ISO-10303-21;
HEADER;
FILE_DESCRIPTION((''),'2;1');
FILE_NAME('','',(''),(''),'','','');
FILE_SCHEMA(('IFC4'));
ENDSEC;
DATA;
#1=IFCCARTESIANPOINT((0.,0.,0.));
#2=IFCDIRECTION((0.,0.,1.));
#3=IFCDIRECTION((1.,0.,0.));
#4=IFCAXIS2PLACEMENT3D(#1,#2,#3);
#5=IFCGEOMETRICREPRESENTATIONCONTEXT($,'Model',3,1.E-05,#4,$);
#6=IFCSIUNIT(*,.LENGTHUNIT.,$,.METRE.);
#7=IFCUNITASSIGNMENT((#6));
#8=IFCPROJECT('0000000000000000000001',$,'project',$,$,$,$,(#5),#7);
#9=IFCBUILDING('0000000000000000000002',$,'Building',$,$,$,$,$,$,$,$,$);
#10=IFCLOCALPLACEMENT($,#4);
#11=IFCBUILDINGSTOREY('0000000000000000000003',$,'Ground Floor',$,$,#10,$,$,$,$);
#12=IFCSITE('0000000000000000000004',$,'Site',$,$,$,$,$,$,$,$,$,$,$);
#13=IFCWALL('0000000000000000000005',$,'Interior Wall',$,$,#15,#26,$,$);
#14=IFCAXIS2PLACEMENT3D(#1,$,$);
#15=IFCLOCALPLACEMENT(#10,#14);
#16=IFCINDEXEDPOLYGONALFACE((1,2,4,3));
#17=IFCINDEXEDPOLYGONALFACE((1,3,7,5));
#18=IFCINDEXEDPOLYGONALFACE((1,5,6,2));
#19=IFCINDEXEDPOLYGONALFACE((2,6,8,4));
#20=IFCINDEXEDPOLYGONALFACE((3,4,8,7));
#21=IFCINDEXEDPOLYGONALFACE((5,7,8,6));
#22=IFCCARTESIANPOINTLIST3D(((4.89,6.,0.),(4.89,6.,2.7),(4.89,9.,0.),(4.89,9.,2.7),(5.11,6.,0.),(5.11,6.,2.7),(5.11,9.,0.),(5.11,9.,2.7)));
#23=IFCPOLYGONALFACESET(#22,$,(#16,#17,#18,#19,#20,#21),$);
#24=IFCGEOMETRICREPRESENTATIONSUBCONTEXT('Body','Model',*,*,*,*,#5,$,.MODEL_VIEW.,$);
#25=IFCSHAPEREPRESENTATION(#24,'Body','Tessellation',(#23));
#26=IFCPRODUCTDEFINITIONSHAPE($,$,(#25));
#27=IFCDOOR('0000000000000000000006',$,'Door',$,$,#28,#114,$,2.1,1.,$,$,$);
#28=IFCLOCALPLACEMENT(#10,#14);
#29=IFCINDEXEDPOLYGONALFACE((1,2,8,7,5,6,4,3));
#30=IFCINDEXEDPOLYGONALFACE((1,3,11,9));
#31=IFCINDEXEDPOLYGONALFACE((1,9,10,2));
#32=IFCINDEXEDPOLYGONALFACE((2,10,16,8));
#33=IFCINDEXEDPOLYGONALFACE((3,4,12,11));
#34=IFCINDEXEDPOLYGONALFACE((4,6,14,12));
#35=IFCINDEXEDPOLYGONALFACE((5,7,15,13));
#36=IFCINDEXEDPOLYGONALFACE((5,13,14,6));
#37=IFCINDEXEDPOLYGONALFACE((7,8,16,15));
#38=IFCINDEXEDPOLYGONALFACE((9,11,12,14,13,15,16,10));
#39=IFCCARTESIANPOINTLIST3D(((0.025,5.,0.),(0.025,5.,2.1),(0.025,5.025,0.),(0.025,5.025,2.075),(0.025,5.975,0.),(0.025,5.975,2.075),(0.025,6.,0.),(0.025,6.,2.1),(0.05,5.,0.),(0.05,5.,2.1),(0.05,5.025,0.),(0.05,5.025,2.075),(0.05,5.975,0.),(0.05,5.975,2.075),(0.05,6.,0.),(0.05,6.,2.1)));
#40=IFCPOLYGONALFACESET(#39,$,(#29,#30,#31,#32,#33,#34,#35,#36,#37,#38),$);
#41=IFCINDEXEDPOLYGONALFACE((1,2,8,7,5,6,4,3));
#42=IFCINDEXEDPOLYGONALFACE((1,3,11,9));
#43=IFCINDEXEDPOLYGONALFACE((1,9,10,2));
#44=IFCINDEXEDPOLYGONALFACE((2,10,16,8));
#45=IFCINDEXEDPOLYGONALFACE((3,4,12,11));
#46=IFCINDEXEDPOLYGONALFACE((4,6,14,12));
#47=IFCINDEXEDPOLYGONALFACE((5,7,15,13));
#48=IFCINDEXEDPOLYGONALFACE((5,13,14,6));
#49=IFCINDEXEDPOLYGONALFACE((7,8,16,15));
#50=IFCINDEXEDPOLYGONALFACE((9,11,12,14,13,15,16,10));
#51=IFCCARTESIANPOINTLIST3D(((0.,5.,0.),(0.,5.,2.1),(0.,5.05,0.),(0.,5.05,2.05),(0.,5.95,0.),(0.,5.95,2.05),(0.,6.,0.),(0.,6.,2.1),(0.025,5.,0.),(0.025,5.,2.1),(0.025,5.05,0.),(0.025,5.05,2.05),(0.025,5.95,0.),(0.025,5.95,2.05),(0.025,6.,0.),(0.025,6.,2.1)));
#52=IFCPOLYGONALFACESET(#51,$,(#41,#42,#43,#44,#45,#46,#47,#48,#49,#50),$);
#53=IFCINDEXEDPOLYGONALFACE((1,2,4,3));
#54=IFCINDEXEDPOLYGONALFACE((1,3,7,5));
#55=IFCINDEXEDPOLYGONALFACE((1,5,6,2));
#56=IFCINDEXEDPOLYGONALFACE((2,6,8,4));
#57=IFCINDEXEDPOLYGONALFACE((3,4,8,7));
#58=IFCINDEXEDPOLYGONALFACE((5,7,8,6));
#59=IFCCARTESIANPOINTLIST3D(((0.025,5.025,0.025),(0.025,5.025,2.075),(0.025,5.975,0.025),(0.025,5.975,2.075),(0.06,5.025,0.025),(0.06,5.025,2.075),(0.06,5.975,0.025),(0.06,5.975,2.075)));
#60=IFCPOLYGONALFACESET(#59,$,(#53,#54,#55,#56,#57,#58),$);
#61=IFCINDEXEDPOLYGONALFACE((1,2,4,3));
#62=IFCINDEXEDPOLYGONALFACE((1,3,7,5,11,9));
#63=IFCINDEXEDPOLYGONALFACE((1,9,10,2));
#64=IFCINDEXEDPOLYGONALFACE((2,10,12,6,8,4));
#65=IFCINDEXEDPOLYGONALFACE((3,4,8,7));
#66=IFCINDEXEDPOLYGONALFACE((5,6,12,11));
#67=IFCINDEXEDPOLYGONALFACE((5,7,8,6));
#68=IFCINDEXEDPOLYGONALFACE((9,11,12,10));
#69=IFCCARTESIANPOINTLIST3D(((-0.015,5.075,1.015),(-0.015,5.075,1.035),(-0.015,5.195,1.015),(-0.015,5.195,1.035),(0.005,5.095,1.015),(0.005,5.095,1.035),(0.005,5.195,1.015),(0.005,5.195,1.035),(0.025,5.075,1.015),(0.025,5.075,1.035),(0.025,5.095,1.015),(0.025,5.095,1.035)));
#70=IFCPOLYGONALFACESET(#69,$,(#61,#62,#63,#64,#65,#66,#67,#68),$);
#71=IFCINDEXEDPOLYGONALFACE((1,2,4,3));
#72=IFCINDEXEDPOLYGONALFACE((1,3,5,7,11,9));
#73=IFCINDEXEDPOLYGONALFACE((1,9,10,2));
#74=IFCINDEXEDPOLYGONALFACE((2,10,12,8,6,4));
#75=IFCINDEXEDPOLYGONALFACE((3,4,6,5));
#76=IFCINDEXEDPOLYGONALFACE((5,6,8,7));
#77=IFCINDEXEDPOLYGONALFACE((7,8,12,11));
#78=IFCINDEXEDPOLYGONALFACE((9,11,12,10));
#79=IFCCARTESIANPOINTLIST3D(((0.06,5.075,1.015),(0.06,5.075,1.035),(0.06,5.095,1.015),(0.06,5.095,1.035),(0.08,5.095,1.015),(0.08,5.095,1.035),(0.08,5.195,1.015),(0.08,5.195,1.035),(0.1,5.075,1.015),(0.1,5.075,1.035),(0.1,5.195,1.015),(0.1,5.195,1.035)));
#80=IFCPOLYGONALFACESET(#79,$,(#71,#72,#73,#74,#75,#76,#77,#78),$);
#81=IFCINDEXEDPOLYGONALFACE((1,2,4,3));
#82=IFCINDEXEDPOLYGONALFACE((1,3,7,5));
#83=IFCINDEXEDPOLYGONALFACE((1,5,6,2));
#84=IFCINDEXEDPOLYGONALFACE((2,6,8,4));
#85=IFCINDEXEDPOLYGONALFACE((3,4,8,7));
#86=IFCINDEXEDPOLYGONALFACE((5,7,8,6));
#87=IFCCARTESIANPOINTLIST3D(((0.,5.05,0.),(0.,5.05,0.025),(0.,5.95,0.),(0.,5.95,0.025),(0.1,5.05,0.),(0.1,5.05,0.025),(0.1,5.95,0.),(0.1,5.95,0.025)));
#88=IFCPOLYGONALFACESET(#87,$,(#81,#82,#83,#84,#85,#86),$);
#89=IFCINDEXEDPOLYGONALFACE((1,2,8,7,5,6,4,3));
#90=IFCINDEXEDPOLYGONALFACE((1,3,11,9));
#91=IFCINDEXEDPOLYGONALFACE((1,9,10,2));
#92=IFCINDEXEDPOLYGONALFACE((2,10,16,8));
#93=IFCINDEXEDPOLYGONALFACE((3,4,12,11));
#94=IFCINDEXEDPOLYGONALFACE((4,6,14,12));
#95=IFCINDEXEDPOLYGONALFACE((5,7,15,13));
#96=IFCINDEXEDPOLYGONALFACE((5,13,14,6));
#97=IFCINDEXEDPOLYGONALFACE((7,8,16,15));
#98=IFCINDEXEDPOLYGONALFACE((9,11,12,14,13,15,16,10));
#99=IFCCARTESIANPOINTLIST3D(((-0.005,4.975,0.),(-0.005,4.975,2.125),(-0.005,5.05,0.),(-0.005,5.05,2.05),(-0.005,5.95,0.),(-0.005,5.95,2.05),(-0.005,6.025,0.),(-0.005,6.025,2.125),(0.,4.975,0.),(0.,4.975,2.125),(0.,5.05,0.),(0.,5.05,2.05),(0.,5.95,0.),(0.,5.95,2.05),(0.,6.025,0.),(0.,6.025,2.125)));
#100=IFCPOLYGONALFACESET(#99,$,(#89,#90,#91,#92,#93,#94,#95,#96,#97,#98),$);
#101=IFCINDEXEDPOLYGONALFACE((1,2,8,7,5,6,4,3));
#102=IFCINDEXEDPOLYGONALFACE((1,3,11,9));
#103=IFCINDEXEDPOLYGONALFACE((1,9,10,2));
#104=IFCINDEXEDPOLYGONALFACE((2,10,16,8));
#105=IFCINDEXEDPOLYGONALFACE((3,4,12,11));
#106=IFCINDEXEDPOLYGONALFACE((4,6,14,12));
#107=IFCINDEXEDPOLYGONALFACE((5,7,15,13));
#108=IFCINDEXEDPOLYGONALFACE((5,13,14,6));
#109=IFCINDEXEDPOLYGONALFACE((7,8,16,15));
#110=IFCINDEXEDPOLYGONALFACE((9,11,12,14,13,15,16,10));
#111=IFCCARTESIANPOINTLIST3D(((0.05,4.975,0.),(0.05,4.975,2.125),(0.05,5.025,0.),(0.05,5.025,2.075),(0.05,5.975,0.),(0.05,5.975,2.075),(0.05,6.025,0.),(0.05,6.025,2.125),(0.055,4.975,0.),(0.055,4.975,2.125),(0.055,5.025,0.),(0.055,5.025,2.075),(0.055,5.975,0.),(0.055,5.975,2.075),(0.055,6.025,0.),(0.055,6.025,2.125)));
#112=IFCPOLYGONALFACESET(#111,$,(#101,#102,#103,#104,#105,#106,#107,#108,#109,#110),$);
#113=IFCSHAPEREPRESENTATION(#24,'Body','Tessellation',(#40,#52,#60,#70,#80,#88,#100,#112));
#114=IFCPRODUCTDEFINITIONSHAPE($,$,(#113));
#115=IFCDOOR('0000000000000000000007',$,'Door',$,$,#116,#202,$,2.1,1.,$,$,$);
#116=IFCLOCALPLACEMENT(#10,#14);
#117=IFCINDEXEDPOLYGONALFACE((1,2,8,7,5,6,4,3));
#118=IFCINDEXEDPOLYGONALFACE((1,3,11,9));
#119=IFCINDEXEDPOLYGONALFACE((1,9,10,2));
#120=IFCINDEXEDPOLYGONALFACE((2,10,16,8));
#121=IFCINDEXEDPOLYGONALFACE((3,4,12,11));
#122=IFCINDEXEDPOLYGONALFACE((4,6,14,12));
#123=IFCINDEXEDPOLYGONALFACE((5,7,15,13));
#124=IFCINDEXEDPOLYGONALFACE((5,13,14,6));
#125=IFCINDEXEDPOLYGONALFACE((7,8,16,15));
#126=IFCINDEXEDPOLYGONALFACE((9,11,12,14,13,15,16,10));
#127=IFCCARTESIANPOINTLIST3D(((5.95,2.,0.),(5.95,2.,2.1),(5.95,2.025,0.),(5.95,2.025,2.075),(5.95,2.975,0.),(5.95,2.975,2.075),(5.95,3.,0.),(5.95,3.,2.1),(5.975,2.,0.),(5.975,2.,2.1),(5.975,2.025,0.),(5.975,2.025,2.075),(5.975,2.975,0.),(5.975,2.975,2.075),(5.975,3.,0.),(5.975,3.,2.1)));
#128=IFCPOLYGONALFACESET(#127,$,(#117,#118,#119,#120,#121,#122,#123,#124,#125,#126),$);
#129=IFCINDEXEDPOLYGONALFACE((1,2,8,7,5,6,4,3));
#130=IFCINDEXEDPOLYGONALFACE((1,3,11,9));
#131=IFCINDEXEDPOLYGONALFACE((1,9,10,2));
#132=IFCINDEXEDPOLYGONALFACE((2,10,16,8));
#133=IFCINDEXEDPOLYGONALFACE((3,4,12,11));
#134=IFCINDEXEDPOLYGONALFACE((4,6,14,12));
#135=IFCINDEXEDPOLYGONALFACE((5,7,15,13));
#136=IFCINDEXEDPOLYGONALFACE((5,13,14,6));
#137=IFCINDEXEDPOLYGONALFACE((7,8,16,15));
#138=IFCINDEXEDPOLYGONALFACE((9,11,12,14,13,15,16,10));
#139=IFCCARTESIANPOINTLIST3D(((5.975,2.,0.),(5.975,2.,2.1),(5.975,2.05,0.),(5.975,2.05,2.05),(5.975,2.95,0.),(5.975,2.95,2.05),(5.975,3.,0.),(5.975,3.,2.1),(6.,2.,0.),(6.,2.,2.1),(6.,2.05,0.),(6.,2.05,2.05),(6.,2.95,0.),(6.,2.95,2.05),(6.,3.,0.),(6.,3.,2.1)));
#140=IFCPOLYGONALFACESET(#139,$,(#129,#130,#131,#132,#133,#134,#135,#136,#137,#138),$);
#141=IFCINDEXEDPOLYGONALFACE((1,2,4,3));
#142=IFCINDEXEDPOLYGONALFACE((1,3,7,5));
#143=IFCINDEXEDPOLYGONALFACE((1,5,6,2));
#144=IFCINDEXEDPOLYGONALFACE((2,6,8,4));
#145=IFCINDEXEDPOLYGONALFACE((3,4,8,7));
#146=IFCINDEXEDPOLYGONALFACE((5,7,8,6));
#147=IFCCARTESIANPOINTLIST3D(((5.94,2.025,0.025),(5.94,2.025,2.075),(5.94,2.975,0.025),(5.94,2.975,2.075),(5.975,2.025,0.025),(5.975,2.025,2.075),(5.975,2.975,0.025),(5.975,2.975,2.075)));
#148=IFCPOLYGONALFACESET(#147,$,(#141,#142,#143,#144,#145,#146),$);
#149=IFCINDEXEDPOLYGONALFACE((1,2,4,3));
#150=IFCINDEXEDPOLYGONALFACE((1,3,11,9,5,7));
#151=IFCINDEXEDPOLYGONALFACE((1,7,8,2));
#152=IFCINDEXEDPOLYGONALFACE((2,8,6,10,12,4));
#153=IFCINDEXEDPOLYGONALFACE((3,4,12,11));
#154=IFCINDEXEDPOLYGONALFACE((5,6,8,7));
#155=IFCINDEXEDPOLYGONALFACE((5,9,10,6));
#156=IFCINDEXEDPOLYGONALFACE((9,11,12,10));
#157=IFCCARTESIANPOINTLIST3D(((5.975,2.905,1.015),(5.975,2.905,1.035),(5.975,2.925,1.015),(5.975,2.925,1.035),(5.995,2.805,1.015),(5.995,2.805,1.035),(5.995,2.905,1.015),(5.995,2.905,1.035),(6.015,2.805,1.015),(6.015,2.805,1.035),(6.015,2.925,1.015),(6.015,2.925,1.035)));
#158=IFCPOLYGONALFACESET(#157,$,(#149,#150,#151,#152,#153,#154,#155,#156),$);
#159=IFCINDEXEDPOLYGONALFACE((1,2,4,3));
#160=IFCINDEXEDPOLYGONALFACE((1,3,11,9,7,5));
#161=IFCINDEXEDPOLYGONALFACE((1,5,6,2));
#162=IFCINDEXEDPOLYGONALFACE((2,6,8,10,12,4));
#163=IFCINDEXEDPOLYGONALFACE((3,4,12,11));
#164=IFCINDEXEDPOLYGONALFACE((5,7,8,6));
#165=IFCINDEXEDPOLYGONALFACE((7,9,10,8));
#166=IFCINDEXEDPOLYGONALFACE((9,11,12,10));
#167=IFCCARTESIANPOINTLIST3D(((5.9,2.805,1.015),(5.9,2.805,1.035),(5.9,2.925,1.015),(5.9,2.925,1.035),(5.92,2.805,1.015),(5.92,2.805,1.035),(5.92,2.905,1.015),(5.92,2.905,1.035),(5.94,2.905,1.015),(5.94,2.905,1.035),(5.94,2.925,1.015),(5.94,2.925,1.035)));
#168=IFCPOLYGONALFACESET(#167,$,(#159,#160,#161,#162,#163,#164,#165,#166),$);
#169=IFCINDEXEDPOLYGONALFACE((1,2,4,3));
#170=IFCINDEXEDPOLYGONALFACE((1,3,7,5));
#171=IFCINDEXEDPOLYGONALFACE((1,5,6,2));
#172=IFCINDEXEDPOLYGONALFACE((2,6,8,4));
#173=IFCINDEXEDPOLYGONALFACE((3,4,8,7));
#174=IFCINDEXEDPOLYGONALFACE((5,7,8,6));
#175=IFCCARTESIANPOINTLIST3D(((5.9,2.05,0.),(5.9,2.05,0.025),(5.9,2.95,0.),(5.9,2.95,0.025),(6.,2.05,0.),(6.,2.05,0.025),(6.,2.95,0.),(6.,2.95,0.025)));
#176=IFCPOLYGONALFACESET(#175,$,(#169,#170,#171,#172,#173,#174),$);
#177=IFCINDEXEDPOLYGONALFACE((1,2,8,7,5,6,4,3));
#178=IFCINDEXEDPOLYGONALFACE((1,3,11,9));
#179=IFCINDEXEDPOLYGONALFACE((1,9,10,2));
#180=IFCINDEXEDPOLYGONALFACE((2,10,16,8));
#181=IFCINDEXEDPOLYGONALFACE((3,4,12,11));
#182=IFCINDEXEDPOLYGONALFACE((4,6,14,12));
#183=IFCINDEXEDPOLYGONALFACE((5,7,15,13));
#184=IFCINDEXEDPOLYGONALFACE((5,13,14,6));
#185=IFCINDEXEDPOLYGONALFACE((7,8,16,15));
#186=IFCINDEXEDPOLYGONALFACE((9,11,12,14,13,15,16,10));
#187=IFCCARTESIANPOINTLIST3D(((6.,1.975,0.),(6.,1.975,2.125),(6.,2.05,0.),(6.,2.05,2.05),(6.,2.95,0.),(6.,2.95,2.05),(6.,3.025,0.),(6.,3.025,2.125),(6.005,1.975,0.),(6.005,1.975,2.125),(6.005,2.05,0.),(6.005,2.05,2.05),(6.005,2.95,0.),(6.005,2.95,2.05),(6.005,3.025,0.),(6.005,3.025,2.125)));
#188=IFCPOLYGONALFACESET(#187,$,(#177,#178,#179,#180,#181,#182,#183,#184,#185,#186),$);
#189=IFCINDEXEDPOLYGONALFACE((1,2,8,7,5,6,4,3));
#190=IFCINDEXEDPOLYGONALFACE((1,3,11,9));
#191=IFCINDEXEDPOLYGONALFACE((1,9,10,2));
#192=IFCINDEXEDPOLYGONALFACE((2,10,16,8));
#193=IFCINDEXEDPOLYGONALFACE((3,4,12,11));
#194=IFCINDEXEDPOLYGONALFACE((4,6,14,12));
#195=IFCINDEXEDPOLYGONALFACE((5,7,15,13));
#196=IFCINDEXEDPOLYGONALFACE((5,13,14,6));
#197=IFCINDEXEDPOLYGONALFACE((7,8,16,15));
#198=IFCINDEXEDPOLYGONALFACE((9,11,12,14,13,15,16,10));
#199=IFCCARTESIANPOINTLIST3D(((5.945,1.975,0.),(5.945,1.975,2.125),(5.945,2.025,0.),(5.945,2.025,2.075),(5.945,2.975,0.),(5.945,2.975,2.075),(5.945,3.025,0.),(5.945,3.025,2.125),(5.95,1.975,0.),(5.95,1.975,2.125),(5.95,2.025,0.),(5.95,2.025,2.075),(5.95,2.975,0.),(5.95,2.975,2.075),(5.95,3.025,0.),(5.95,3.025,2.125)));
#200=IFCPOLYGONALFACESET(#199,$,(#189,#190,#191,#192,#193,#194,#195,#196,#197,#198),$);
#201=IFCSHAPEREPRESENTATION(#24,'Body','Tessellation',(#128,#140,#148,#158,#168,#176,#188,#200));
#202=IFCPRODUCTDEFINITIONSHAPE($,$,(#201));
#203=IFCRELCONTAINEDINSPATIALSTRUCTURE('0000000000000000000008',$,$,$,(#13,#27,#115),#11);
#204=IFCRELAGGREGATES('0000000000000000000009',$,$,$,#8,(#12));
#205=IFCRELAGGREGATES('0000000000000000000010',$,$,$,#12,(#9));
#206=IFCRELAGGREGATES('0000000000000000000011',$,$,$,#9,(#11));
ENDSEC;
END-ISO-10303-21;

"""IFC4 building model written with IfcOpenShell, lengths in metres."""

from ifc_helpers import new_model, si_unit, frame, origin_with_axes, place, context, subcontext, project, spatial, line, indexed_curve, outline, extrude, element, save


model = new_model("IFC4")

# Units and contexts
model_context = context("Model", 3, precision=1e-05, world=origin_with_axes())
body_context = subcontext(model_context, "Body", "Model", "MODEL_VIEW")
ifc_project = project(units=[si_unit("LENGTHUNIT", "METRE")], contexts=[model_context])

# Site, building, storey
site = spatial("IfcSite", under=ifc_project, Name="Site")
building = spatial("IfcBuilding", under=site, Name="Building")
storey_placement = place(None, origin_with_axes())
storey = spatial("IfcBuildingStorey", under=building, at=storey_placement, Name="Ground Floor")

# Wall
wall_1_placement = place(storey_placement, frame((5.0, 6.0, 0.0), z_axis=(0.0, 0.0, 1.0), x_axis=(0.0, 1.0, 0.0)))
element("IfcWall", 1, at=wall_1_placement, inside=storey, Name="Interior Wall", context=body_context, shape_type="SweptSolid", body=[
    extrude(outline(indexed_curve([(0.0, 0.0), (0.0, 0.22), (3.0, 0.22), (3.0, 0.0), (0.0, 0.0)], self_intersect=False)), frame((0.0, -0.11, 0.0), z_axis=(0.0, 0.0, 1.0), x_axis=(1.0, 0.0, 0.0)), (0.0, 0.0, 1.0), 2.7),
])

# Doors
door_1_placement = place(storey_placement, frame((0.0, 6.0, 0.0), z_axis=(0.0, 0.0, 1.0), x_axis=(0.0, -1.0, 0.0)))
element("IfcDoor", 2, at=door_1_placement, inside=storey, Name="Door", OverallHeight=2.1, OverallWidth=1.0, context=body_context, shape_type="SweptSolid", body=[
    extrude(outline(indexed_curve([(0.0, 0.0), (0.0, 2.1), (1.0, 2.1), (1.0, 0.0), (0.975, 0.0), (0.975, 2.075), (0.025, 2.075), (0.025, 0.0)], segments=[line(1, 2, 3, 4, 5, 6, 7, 8, 1)])), frame((0.0, 0.025, 0.0), z_axis=(0.0, -1.0, 0.0), x_axis=(1.0, 0.0, 0.0)), (0.0, 0.0, -1.0), 0.025),
    extrude(outline(indexed_curve([(0.0, 0.0), (0.0, 2.1), (1.0, 2.1), (1.0, 0.0), (0.95, 0.0), (0.95, 2.05), (0.05, 2.05), (0.05, 0.0)], segments=[line(1, 2, 3, 4, 5, 6, 7, 8, 1)])), frame((0.0, 0.0, 0.0), z_axis=(0.0, -1.0, 0.0), x_axis=(1.0, 0.0, 0.0)), (0.0, 0.0, -1.0), 0.025),
    extrude(outline(indexed_curve([(0.0, 0.0), (0.95, 0.0), (0.95, 0.035), (0.0, 0.035)], segments=[line(1, 2, 3, 4, 1)])), frame((0.025, 0.025, 0.025), z_axis=(0.0, 0.0, 1.0), x_axis=(1.0, 0.0, 0.0)), (0.0, 0.0, 1.0), 2.05),
    extrude(outline(indexed_curve([(0.0, 0.0), (0.0, -0.04), (-0.12, -0.04), (-0.12, -0.02), (-0.02, -0.02), (-0.02, 0.0)], segments=[line(1, 2, 3, 4, 5, 6, 1)])), frame((0.925, 0.025, 1.015), z_axis=(0.0, 0.0, 1.0), x_axis=(1.0, 0.0, 0.0)), (0.0, 0.0, 1.0), 0.02),
    extrude(outline(indexed_curve([(0.0, 0.0), (0.0, 0.04), (-0.12, 0.04), (-0.12, 0.02), (-0.02, 0.02), (-0.02, 0.0)], segments=[line(1, 2, 3, 4, 5, 6, 1)])), frame((0.925, 0.06, 1.015), z_axis=(0.0, 0.0, 1.0), x_axis=(1.0, 0.0, 0.0)), (0.0, 0.0, 1.0), 0.02),
    extrude(outline(indexed_curve([(0.0, 0.0), (0.9, 0.0), (0.9, 0.1), (0.0, 0.1)], segments=[line(1, 2, 3, 4, 1)])), frame((0.05, 0.0, 0.0), z_axis=(0.0, 0.0, 1.0), x_axis=(1.0, 0.0, 0.0)), (0.0, 0.0, 1.0), 0.025),
    extrude(outline(indexed_curve([(0.0, 0.0), (0.0, 2.125), (1.05, 2.125), (1.05, 0.0), (0.975, 0.0), (0.975, 2.05), (0.075, 2.05), (0.075, 0.0)], segments=[line(1, 2, 3, 4, 5, 6, 7, 8, 1)])), frame((-0.025, -0.005, 0.0), z_axis=(0.0, -1.0, 0.0), x_axis=(1.0, 0.0, 0.0)), (0.0, 0.0, -1.0), 0.005),
    extrude(outline(indexed_curve([(0.0, 0.0), (0.0, 2.125), (1.05, 2.125), (1.05, 0.0), (1.0, 0.0), (1.0, 2.075), (0.05, 2.075), (0.05, 0.0)], segments=[line(1, 2, 3, 4, 5, 6, 7, 8, 1)])), frame((-0.025, 0.05, 0.0), z_axis=(0.0, -1.0, 0.0), x_axis=(1.0, 0.0, 0.0)), (0.0, 0.0, -1.0), 0.005),
])
door_2_placement = place(storey_placement, frame((6.0, 2.0, 0.0), z_axis=(0.0, 0.0, 1.0), x_axis=(0.0, 1.0, 0.0)))
element("IfcDoor", 3, at=door_2_placement, inside=storey, Name="Door", OverallHeight=2.1, OverallWidth=1.0, context=body_context, shape_type="SweptSolid", body=[
    extrude(outline(indexed_curve([(0.0, 0.0), (0.0, 2.1), (1.0, 2.1), (1.0, 0.0), (0.975, 0.0), (0.975, 2.075), (0.025, 2.075), (0.025, 0.0)], segments=[line(1, 2, 3, 4, 5, 6, 7, 8, 1)])), frame((0.0, 0.025, 0.0), z_axis=(0.0, -1.0, 0.0), x_axis=(1.0, 0.0, 0.0)), (0.0, 0.0, -1.0), 0.025),
    extrude(outline(indexed_curve([(0.0, 0.0), (0.0, 2.1), (1.0, 2.1), (1.0, 0.0), (0.95, 0.0), (0.95, 2.05), (0.05, 2.05), (0.05, 0.0)], segments=[line(1, 2, 3, 4, 5, 6, 7, 8, 1)])), frame((0.0, 0.0, 0.0), z_axis=(0.0, -1.0, 0.0), x_axis=(1.0, 0.0, 0.0)), (0.0, 0.0, -1.0), 0.025),
    extrude(outline(indexed_curve([(0.0, 0.0), (0.95, 0.0), (0.95, 0.035), (0.0, 0.035)], segments=[line(1, 2, 3, 4, 1)])), frame((0.025, 0.025, 0.025), z_axis=(0.0, 0.0, 1.0), x_axis=(1.0, 0.0, 0.0)), (0.0, 0.0, 1.0), 2.05),
    extrude(outline(indexed_curve([(0.0, 0.0), (0.0, -0.04), (-0.12, -0.04), (-0.12, -0.02), (-0.02, -0.02), (-0.02, 0.0)], segments=[line(1, 2, 3, 4, 5, 6, 1)])), frame((0.925, 0.025, 1.015), z_axis=(0.0, 0.0, 1.0), x_axis=(1.0, 0.0, 0.0)), (0.0, 0.0, 1.0), 0.02),
    extrude(outline(indexed_curve([(0.0, 0.0), (0.0, 0.04), (-0.12, 0.04), (-0.12, 0.02), (-0.02, 0.02), (-0.02, 0.0)], segments=[line(1, 2, 3, 4, 5, 6, 1)])), frame((0.925, 0.06, 1.015), z_axis=(0.0, 0.0, 1.0), x_axis=(1.0, 0.0, 0.0)), (0.0, 0.0, 1.0), 0.02),
    extrude(outline(indexed_curve([(0.0, 0.0), (0.9, 0.0), (0.9, 0.1), (0.0, 0.1)], segments=[line(1, 2, 3, 4, 1)])), frame((0.05, 0.0, 0.0), z_axis=(0.0, 0.0, 1.0), x_axis=(1.0, 0.0, 0.0)), (0.0, 0.0, 1.0), 0.025),
    extrude(outline(indexed_curve([(0.0, 0.0), (0.0, 2.125), (1.05, 2.125), (1.05, 0.0), (0.975, 0.0), (0.975, 2.05), (0.075, 2.05), (0.075, 0.0)], segments=[line(1, 2, 3, 4, 5, 6, 7, 8, 1)])), frame((-0.025, -0.005, 0.0), z_axis=(0.0, -1.0, 0.0), x_axis=(1.0, 0.0, 0.0)), (0.0, 0.0, -1.0), 0.005),
    extrude(outline(indexed_curve([(0.0, 0.0), (0.0, 2.125), (1.05, 2.125), (1.05, 0.0), (1.0, 0.0), (1.0, 2.075), (0.05, 2.075), (0.05, 0.0)], segments=[line(1, 2, 3, 4, 5, 6, 7, 8, 1)])), frame((-0.025, 0.05, 0.0), z_axis=(0.0, -1.0, 0.0), x_axis=(1.0, 0.0, 0.0)), (0.0, 0.0, -1.0), 0.005),
])

save(model, "model.ifc")
